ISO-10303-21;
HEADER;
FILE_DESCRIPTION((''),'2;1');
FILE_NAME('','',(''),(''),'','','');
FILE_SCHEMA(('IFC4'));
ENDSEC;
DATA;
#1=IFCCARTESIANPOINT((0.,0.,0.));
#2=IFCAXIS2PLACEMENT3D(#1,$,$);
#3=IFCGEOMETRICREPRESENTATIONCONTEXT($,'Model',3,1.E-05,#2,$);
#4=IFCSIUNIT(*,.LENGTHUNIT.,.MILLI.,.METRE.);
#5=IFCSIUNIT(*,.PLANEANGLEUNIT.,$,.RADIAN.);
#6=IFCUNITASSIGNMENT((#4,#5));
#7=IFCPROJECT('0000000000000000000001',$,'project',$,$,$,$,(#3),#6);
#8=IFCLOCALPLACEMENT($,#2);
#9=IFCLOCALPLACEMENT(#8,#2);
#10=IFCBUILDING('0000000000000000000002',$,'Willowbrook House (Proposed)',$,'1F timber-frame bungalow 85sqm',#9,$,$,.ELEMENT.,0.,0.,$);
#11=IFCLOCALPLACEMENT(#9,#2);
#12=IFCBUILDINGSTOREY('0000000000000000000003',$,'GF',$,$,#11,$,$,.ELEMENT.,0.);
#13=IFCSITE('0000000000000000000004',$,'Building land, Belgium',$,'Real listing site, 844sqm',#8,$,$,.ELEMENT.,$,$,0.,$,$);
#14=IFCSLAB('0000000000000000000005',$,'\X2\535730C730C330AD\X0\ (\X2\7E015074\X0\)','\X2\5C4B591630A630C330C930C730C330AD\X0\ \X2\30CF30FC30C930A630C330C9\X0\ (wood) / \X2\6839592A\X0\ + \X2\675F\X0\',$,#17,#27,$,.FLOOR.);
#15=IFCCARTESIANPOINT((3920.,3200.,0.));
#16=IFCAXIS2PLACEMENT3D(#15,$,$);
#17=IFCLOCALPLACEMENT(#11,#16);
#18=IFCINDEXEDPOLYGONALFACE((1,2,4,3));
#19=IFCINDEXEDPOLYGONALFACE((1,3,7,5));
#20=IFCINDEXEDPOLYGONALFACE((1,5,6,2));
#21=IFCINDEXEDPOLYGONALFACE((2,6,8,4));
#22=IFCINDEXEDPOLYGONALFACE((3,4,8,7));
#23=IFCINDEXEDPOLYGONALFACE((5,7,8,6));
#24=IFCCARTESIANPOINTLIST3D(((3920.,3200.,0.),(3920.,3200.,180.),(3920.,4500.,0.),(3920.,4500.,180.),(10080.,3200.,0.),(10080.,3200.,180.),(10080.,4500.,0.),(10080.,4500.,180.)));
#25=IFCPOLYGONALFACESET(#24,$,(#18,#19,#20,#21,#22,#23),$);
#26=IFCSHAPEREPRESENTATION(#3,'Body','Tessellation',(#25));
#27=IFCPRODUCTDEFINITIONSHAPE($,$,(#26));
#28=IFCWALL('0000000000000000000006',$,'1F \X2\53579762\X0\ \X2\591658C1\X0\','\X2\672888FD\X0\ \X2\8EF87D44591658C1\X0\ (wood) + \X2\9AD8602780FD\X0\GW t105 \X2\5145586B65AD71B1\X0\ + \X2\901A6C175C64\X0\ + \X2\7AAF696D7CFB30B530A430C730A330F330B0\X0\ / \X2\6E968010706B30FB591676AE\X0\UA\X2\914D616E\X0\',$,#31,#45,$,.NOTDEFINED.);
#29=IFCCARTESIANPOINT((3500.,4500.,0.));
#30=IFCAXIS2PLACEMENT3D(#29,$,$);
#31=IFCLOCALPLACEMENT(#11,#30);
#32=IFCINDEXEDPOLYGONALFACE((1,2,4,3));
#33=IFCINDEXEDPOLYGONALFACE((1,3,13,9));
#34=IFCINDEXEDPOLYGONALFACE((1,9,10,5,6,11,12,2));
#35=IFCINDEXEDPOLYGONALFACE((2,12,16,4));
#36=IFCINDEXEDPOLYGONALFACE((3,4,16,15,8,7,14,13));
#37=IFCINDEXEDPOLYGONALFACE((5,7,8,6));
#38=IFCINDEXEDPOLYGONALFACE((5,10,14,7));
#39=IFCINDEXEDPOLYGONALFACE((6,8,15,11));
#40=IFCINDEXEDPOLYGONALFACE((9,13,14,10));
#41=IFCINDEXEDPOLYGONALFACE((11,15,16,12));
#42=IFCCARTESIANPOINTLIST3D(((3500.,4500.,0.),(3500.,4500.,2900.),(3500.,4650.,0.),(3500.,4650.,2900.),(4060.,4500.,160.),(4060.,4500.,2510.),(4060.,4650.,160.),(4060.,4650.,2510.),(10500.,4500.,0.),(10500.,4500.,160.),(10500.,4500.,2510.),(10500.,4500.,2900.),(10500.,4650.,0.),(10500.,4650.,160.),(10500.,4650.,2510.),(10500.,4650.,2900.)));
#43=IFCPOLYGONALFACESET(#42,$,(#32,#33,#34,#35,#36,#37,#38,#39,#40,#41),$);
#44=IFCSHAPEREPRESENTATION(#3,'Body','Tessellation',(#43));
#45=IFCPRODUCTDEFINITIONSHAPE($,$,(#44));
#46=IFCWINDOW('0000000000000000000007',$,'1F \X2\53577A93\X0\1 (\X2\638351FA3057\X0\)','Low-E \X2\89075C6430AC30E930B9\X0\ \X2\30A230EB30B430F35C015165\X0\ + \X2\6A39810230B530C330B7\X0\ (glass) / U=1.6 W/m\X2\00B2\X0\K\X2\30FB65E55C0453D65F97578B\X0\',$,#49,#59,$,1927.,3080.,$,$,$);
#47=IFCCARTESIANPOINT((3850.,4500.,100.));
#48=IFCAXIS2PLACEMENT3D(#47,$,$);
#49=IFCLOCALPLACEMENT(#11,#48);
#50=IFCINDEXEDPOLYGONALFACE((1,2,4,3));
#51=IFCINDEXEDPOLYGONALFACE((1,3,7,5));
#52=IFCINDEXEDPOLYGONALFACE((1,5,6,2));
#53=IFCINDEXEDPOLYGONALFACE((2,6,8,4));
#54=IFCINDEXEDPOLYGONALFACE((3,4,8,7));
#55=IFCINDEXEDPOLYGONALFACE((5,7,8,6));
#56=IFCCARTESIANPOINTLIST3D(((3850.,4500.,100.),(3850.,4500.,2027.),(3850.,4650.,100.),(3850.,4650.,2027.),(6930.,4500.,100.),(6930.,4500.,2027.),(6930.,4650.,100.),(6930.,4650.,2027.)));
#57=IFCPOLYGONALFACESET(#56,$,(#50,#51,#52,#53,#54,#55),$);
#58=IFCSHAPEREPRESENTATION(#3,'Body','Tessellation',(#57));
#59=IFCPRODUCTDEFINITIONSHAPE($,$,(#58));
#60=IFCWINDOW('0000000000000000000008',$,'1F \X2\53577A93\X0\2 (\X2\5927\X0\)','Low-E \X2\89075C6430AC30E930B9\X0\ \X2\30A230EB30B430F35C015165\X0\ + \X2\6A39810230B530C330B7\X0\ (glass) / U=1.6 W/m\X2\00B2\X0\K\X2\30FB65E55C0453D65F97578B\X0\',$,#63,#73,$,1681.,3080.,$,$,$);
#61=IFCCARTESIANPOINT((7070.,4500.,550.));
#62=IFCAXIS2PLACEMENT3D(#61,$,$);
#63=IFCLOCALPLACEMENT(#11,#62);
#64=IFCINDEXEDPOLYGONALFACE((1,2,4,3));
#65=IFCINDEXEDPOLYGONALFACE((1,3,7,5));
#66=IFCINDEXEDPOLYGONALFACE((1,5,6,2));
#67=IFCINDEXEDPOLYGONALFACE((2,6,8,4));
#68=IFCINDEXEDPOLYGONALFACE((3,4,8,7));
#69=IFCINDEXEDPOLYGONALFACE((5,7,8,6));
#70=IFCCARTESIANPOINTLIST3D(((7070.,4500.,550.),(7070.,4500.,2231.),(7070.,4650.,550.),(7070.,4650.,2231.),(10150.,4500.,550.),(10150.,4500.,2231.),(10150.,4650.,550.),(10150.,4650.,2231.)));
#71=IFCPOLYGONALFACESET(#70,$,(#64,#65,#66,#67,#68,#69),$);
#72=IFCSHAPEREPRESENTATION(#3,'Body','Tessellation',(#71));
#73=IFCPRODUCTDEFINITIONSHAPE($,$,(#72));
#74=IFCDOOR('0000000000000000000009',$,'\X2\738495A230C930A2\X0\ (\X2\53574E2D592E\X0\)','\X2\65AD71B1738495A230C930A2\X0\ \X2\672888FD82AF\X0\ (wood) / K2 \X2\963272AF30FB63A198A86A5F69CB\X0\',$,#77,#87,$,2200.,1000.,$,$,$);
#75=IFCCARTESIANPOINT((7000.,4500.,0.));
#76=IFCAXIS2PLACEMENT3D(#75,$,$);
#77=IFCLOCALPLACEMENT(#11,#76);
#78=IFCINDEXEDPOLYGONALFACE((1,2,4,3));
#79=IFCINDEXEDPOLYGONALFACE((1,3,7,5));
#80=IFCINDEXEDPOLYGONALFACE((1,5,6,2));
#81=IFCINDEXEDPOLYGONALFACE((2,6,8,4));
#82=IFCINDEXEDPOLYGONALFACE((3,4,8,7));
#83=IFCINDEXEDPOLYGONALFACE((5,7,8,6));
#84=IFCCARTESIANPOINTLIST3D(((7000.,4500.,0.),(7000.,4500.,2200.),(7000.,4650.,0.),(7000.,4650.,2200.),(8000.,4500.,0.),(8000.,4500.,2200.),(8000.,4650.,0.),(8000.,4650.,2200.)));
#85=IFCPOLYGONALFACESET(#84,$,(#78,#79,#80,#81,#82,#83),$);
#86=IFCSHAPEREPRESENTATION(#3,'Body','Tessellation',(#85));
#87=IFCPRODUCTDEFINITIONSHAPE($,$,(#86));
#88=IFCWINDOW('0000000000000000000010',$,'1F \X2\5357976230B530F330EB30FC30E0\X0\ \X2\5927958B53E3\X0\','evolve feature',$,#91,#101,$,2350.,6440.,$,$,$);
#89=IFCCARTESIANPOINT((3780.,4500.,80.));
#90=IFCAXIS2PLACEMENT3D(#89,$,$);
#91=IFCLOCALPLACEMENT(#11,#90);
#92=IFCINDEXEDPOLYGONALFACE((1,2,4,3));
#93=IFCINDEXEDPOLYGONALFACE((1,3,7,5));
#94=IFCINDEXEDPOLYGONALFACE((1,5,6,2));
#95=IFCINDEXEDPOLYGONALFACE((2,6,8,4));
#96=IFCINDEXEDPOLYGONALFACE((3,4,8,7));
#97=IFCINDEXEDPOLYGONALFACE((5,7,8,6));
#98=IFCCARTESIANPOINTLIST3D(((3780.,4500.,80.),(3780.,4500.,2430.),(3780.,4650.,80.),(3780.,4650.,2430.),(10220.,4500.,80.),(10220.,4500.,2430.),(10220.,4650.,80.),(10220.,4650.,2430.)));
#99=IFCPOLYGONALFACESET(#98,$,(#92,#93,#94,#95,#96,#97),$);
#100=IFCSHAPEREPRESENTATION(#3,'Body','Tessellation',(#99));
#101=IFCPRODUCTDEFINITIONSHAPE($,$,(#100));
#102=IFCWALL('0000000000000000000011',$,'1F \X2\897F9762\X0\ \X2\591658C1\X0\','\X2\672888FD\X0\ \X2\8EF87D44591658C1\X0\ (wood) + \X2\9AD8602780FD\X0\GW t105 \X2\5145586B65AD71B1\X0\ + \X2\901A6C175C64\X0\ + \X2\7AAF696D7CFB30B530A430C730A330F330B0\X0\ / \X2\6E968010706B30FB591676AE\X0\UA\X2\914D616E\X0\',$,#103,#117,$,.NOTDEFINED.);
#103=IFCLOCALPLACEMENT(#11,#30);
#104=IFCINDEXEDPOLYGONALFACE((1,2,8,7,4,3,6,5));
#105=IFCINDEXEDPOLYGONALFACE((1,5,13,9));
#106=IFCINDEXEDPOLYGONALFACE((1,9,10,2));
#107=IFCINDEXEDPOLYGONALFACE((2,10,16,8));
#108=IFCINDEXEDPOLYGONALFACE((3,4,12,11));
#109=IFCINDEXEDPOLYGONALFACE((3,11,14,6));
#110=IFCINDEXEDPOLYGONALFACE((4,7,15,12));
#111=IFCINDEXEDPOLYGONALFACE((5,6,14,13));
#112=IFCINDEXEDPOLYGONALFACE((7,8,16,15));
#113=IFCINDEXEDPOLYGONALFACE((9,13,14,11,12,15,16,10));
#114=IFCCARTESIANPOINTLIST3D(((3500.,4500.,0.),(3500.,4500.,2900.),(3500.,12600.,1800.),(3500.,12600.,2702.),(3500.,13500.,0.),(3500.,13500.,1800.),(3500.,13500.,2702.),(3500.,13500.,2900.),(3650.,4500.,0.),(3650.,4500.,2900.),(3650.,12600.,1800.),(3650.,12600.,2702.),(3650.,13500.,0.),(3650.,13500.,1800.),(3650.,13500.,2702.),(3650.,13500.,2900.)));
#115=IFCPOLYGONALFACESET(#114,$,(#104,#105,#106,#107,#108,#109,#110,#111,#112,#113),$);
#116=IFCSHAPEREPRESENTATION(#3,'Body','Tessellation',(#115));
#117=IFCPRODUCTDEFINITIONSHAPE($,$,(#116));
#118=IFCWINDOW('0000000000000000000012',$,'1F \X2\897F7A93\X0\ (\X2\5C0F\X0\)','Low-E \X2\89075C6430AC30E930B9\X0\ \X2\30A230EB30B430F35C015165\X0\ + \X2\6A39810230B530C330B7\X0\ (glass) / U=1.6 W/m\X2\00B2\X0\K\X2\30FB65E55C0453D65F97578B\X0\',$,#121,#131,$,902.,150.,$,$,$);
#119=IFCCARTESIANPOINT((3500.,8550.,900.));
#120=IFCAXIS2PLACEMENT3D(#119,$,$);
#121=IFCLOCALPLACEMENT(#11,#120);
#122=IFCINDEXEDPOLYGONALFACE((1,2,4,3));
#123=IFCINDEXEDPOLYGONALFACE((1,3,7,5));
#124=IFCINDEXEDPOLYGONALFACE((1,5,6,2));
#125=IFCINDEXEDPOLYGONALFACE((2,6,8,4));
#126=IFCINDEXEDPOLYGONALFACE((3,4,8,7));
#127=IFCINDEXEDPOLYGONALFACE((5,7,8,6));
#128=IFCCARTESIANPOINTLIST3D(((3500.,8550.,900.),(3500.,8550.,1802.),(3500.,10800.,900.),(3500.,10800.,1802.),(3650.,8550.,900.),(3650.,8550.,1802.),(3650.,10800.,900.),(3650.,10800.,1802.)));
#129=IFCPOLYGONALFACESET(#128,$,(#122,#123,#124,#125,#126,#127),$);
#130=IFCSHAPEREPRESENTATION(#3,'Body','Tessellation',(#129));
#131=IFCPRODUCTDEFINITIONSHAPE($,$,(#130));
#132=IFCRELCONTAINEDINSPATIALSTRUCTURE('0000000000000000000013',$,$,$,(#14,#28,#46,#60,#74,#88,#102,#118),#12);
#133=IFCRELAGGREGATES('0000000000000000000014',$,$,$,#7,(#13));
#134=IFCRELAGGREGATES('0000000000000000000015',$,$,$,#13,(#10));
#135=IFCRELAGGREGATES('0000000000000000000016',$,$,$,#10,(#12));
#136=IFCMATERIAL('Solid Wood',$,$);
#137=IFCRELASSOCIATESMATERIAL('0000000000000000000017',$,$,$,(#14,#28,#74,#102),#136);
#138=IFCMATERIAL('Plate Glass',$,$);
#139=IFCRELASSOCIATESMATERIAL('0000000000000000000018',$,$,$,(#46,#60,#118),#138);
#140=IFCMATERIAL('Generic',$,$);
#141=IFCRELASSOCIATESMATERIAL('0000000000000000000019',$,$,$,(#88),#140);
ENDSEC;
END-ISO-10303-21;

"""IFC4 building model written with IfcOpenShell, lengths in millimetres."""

from ifc_helpers import new_model, si_unit, frame, frame_2d, origin, place, context, project, spatial, rectangle, extrude, material, element, fill, save


model = new_model("IFC4")

# Units and contexts
model_context = context("Model", 3, precision=1e-05, world=origin())
ifc_project = project(units=[si_unit("LENGTHUNIT", "METRE", prefix="MILLI"), si_unit("PLANEANGLEUNIT", "RADIAN")], contexts=[model_context])

# Site, building, storey
site_placement = place(None, origin())
site = spatial("IfcSite", under=ifc_project, at=site_placement, Name="Building land, Belgium", ObjectType="Real listing site, 844sqm", CompositionType="ELEMENT", RefElevation=0.0)
building_placement = place(site_placement, origin())
building = spatial("IfcBuilding", under=site, at=building_placement, Name="Willowbrook House (Proposed)", ObjectType="1F timber-frame bungalow 85sqm", CompositionType="ELEMENT", ElevationOfRefHeight=0.0, ElevationOfTerrain=0.0)
storey_placement = place(building_placement, origin())
storey = spatial("IfcBuildingStorey", under=building, at=storey_placement, Name="GF", CompositionType="ELEMENT", Elevation=0.0)

# Slab
ifc_material_1 = material(Name="Solid Wood")
slab_1_placement = place(storey_placement, frame((3920.0, 3200.0, 0.0)))
element("IfcSlab", 1, at=slab_1_placement, inside=storey, material=ifc_material_1, Name="南デッキ (縁側)", Description="屋外ウッドデッキ ハードウッド (wood) / 根太 + 束", PredefinedType="FLOOR", context=model_context, shape_type="SweptSolid", body=[
    extrude(rectangle(XDim=6160.0, YDim=1300.0, at=frame_2d((3080.0, 650.0))), frame((3920.0, 3200.0, 0.0)), (0.0, 0.0, 1.0), 180.0),
])
ifc_material_2 = material(Name="Generic")

# Wall, openings, windows, door
wall_1_placement = place(storey_placement, frame((3500.0, 4500.0, 0.0)))
wall_1 = element("IfcWall", 2, at=wall_1_placement, inside=storey, material=ifc_material_1, Name="1F 南面 外壁", Description="木製 軸組外壁 (wood) + 高性能GW t105 充填断熱 + 通気層 + 窯業系サイディング / 準耐火・外皮UA配慮", PredefinedType="NOTDEFINED", context=model_context, shape_type="SweptSolid", body=[
    extrude(rectangle(XDim=7000.0, YDim=150.0, at=frame_2d((3500.0, 75.0))), frame((3500.0, 4500.0, 0.0)), (0.0, 0.0, 1.0), 2900.0),
])
opening_1_placement = place(storey_placement, frame((3850.0, 4500.0, 100.0)))
opening_1 = element("IfcOpeningElement", 3, at=opening_1_placement, cuts=wall_1, PredefinedType="NOTDEFINED", context=model_context, shape_type="SweptSolid", body=[
    extrude(rectangle(XDim=3080.0, YDim=150.0, at=frame_2d((1540.0, 75.0))), frame((3850.0, 4500.0, 100.0)), (0.0, 0.0, 1.0), 1927.0),
])
opening_2_placement = place(storey_placement, frame((7070.0, 4500.0, 550.0)))
opening_2 = element("IfcOpeningElement", 4, at=opening_2_placement, cuts=wall_1, PredefinedType="NOTDEFINED", context=model_context, shape_type="SweptSolid", body=[
    extrude(rectangle(XDim=3080.0, YDim=150.0, at=frame_2d((1540.0, 75.0))), frame((7070.0, 4500.0, 550.0)), (0.0, 0.0, 1.0), 1681.0),
])
opening_3_placement = place(storey_placement, frame((7000.0, 4500.0, 0.0)))
opening_3 = element("IfcOpeningElement", 5, at=opening_3_placement, cuts=wall_1, PredefinedType="NOTDEFINED", context=model_context, shape_type="SweptSolid", body=[
    extrude(rectangle(XDim=1000.0, YDim=150.0, at=frame_2d((500.0, 75.0))), frame((7000.0, 4500.0, 0.0)), (0.0, 0.0, 1.0), 2200.0),
])
opening_4_placement = place(storey_placement, frame((3780.0, 4500.0, 80.0)))
opening_4 = element("IfcOpeningElement", 6, at=opening_4_placement, cuts=wall_1, PredefinedType="NOTDEFINED", context=model_context, shape_type="SweptSolid", body=[
    extrude(rectangle(XDim=6440.0, YDim=150.0, at=frame_2d((3220.0, 75.0))), frame((3780.0, 4500.0, 80.0)), (0.0, 0.0, 1.0), 2350.0),
])
ifc_material_3 = material(Name="Plate Glass")
window_1_placement = place(storey_placement, frame((3850.0, 4500.0, 100.0)))
window_1 = element("IfcWindow", 7, at=window_1_placement, inside=storey, material=ifc_material_3, Name="1F 南窓1 (掃出し)", Description="Low-E 複層ガラス アルゴン封入 + 樹脂サッシ (glass) / U=1.6 W/m²K・日射取得型", OverallHeight=1927.0, OverallWidth=3080.0, context=model_context, shape_type="SweptSolid", body=[
    extrude(rectangle(XDim=3080.0, YDim=150.0, at=frame_2d((1540.0, 75.0))), frame((3850.0, 4500.0, 100.0)), (0.0, 0.0, 1.0), 1927.0),
])
fill(opening_1, window_1)
window_2_placement = place(storey_placement, frame((7070.0, 4500.0, 550.0)))
window_2 = element("IfcWindow", 8, at=window_2_placement, inside=storey, material=ifc_material_3, Name="1F 南窓2 (大)", Description="Low-E 複層ガラス アルゴン封入 + 樹脂サッシ (glass) / U=1.6 W/m²K・日射取得型", OverallHeight=1681.0, OverallWidth=3080.0, context=model_context, shape_type="SweptSolid", body=[
    extrude(rectangle(XDim=3080.0, YDim=150.0, at=frame_2d((1540.0, 75.0))), frame((7070.0, 4500.0, 550.0)), (0.0, 0.0, 1.0), 1681.0),
])
fill(opening_2, window_2)
door_placement = place(storey_placement, frame((7000.0, 4500.0, 0.0)))
door = element("IfcDoor", 9, at=door_placement, inside=storey, material=ifc_material_1, Name="玄関ドア (南中央)", Description="断熱玄関ドア 木製芯 (wood) / K2 防犯・採風機構", OverallHeight=2200.0, OverallWidth=1000.0, context=model_context, shape_type="SweptSolid", body=[
    extrude(rectangle(XDim=1000.0, YDim=150.0, at=frame_2d((500.0, 75.0))), frame((7000.0, 4500.0, 0.0)), (0.0, 0.0, 1.0), 2200.0),
])
fill(opening_3, door)
window_3_placement = place(storey_placement, frame((3780.0, 4500.0, 80.0)))
window_3 = element("IfcWindow", 10, at=window_3_placement, inside=storey, material=ifc_material_2, Name="1F 南面サンルーム 大開口", Description="evolve feature", OverallHeight=2350.0, OverallWidth=6440.0, context=model_context, shape_type="SweptSolid", body=[
    extrude(rectangle(XDim=6440.0, YDim=150.0, at=frame_2d((3220.0, 75.0))), frame((3780.0, 4500.0, 80.0)), (0.0, 0.0, 1.0), 2350.0),
])
fill(opening_4, window_3)

# Wall, opening, window
wall_2_placement = place(storey_placement, frame((3500.0, 4500.0, 0.0)))
wall_2 = element("IfcWall", 11, at=wall_2_placement, inside=storey, material=ifc_material_1, Name="1F 西面 外壁", Description="木製 軸組外壁 (wood) + 高性能GW t105 充填断熱 + 通気層 + 窯業系サイディング / 準耐火・外皮UA配慮", PredefinedType="NOTDEFINED", context=model_context, shape_type="SweptSolid", body=[
    extrude(rectangle(XDim=150.0, YDim=9000.0, at=frame_2d((75.0, 4500.0))), frame((3500.0, 4500.0, 0.0)), (0.0, 0.0, 1.0), 2900.0),
])
opening_5_placement = place(storey_placement, frame((3500.0, 8550.0, 900.0)))
opening_5 = element("IfcOpeningElement", 12, at=opening_5_placement, cuts=wall_2, PredefinedType="NOTDEFINED", context=model_context, shape_type="SweptSolid", body=[
    extrude(rectangle(XDim=150.0, YDim=2250.0, at=frame_2d((75.0, 1125.0))), frame((3500.0, 8550.0, 900.0)), (0.0, 0.0, 1.0), 902.0),
])
window_4_placement = place(storey_placement, frame((3500.0, 8550.0, 900.0)))
window_4 = element("IfcWindow", 13, at=window_4_placement, inside=storey, material=ifc_material_3, Name="1F 西窓 (小)", Description="Low-E 複層ガラス アルゴン封入 + 樹脂サッシ (glass) / U=1.6 W/m²K・日射取得型", OverallHeight=902.0, OverallWidth=150.0, context=model_context, shape_type="SweptSolid", body=[
    extrude(rectangle(XDim=150.0, YDim=2250.0, at=frame_2d((75.0, 1125.0))), frame((3500.0, 8550.0, 900.0)), (0.0, 0.0, 1.0), 902.0),
])
fill(opening_5, window_4)

save(model, "model.ifc")
